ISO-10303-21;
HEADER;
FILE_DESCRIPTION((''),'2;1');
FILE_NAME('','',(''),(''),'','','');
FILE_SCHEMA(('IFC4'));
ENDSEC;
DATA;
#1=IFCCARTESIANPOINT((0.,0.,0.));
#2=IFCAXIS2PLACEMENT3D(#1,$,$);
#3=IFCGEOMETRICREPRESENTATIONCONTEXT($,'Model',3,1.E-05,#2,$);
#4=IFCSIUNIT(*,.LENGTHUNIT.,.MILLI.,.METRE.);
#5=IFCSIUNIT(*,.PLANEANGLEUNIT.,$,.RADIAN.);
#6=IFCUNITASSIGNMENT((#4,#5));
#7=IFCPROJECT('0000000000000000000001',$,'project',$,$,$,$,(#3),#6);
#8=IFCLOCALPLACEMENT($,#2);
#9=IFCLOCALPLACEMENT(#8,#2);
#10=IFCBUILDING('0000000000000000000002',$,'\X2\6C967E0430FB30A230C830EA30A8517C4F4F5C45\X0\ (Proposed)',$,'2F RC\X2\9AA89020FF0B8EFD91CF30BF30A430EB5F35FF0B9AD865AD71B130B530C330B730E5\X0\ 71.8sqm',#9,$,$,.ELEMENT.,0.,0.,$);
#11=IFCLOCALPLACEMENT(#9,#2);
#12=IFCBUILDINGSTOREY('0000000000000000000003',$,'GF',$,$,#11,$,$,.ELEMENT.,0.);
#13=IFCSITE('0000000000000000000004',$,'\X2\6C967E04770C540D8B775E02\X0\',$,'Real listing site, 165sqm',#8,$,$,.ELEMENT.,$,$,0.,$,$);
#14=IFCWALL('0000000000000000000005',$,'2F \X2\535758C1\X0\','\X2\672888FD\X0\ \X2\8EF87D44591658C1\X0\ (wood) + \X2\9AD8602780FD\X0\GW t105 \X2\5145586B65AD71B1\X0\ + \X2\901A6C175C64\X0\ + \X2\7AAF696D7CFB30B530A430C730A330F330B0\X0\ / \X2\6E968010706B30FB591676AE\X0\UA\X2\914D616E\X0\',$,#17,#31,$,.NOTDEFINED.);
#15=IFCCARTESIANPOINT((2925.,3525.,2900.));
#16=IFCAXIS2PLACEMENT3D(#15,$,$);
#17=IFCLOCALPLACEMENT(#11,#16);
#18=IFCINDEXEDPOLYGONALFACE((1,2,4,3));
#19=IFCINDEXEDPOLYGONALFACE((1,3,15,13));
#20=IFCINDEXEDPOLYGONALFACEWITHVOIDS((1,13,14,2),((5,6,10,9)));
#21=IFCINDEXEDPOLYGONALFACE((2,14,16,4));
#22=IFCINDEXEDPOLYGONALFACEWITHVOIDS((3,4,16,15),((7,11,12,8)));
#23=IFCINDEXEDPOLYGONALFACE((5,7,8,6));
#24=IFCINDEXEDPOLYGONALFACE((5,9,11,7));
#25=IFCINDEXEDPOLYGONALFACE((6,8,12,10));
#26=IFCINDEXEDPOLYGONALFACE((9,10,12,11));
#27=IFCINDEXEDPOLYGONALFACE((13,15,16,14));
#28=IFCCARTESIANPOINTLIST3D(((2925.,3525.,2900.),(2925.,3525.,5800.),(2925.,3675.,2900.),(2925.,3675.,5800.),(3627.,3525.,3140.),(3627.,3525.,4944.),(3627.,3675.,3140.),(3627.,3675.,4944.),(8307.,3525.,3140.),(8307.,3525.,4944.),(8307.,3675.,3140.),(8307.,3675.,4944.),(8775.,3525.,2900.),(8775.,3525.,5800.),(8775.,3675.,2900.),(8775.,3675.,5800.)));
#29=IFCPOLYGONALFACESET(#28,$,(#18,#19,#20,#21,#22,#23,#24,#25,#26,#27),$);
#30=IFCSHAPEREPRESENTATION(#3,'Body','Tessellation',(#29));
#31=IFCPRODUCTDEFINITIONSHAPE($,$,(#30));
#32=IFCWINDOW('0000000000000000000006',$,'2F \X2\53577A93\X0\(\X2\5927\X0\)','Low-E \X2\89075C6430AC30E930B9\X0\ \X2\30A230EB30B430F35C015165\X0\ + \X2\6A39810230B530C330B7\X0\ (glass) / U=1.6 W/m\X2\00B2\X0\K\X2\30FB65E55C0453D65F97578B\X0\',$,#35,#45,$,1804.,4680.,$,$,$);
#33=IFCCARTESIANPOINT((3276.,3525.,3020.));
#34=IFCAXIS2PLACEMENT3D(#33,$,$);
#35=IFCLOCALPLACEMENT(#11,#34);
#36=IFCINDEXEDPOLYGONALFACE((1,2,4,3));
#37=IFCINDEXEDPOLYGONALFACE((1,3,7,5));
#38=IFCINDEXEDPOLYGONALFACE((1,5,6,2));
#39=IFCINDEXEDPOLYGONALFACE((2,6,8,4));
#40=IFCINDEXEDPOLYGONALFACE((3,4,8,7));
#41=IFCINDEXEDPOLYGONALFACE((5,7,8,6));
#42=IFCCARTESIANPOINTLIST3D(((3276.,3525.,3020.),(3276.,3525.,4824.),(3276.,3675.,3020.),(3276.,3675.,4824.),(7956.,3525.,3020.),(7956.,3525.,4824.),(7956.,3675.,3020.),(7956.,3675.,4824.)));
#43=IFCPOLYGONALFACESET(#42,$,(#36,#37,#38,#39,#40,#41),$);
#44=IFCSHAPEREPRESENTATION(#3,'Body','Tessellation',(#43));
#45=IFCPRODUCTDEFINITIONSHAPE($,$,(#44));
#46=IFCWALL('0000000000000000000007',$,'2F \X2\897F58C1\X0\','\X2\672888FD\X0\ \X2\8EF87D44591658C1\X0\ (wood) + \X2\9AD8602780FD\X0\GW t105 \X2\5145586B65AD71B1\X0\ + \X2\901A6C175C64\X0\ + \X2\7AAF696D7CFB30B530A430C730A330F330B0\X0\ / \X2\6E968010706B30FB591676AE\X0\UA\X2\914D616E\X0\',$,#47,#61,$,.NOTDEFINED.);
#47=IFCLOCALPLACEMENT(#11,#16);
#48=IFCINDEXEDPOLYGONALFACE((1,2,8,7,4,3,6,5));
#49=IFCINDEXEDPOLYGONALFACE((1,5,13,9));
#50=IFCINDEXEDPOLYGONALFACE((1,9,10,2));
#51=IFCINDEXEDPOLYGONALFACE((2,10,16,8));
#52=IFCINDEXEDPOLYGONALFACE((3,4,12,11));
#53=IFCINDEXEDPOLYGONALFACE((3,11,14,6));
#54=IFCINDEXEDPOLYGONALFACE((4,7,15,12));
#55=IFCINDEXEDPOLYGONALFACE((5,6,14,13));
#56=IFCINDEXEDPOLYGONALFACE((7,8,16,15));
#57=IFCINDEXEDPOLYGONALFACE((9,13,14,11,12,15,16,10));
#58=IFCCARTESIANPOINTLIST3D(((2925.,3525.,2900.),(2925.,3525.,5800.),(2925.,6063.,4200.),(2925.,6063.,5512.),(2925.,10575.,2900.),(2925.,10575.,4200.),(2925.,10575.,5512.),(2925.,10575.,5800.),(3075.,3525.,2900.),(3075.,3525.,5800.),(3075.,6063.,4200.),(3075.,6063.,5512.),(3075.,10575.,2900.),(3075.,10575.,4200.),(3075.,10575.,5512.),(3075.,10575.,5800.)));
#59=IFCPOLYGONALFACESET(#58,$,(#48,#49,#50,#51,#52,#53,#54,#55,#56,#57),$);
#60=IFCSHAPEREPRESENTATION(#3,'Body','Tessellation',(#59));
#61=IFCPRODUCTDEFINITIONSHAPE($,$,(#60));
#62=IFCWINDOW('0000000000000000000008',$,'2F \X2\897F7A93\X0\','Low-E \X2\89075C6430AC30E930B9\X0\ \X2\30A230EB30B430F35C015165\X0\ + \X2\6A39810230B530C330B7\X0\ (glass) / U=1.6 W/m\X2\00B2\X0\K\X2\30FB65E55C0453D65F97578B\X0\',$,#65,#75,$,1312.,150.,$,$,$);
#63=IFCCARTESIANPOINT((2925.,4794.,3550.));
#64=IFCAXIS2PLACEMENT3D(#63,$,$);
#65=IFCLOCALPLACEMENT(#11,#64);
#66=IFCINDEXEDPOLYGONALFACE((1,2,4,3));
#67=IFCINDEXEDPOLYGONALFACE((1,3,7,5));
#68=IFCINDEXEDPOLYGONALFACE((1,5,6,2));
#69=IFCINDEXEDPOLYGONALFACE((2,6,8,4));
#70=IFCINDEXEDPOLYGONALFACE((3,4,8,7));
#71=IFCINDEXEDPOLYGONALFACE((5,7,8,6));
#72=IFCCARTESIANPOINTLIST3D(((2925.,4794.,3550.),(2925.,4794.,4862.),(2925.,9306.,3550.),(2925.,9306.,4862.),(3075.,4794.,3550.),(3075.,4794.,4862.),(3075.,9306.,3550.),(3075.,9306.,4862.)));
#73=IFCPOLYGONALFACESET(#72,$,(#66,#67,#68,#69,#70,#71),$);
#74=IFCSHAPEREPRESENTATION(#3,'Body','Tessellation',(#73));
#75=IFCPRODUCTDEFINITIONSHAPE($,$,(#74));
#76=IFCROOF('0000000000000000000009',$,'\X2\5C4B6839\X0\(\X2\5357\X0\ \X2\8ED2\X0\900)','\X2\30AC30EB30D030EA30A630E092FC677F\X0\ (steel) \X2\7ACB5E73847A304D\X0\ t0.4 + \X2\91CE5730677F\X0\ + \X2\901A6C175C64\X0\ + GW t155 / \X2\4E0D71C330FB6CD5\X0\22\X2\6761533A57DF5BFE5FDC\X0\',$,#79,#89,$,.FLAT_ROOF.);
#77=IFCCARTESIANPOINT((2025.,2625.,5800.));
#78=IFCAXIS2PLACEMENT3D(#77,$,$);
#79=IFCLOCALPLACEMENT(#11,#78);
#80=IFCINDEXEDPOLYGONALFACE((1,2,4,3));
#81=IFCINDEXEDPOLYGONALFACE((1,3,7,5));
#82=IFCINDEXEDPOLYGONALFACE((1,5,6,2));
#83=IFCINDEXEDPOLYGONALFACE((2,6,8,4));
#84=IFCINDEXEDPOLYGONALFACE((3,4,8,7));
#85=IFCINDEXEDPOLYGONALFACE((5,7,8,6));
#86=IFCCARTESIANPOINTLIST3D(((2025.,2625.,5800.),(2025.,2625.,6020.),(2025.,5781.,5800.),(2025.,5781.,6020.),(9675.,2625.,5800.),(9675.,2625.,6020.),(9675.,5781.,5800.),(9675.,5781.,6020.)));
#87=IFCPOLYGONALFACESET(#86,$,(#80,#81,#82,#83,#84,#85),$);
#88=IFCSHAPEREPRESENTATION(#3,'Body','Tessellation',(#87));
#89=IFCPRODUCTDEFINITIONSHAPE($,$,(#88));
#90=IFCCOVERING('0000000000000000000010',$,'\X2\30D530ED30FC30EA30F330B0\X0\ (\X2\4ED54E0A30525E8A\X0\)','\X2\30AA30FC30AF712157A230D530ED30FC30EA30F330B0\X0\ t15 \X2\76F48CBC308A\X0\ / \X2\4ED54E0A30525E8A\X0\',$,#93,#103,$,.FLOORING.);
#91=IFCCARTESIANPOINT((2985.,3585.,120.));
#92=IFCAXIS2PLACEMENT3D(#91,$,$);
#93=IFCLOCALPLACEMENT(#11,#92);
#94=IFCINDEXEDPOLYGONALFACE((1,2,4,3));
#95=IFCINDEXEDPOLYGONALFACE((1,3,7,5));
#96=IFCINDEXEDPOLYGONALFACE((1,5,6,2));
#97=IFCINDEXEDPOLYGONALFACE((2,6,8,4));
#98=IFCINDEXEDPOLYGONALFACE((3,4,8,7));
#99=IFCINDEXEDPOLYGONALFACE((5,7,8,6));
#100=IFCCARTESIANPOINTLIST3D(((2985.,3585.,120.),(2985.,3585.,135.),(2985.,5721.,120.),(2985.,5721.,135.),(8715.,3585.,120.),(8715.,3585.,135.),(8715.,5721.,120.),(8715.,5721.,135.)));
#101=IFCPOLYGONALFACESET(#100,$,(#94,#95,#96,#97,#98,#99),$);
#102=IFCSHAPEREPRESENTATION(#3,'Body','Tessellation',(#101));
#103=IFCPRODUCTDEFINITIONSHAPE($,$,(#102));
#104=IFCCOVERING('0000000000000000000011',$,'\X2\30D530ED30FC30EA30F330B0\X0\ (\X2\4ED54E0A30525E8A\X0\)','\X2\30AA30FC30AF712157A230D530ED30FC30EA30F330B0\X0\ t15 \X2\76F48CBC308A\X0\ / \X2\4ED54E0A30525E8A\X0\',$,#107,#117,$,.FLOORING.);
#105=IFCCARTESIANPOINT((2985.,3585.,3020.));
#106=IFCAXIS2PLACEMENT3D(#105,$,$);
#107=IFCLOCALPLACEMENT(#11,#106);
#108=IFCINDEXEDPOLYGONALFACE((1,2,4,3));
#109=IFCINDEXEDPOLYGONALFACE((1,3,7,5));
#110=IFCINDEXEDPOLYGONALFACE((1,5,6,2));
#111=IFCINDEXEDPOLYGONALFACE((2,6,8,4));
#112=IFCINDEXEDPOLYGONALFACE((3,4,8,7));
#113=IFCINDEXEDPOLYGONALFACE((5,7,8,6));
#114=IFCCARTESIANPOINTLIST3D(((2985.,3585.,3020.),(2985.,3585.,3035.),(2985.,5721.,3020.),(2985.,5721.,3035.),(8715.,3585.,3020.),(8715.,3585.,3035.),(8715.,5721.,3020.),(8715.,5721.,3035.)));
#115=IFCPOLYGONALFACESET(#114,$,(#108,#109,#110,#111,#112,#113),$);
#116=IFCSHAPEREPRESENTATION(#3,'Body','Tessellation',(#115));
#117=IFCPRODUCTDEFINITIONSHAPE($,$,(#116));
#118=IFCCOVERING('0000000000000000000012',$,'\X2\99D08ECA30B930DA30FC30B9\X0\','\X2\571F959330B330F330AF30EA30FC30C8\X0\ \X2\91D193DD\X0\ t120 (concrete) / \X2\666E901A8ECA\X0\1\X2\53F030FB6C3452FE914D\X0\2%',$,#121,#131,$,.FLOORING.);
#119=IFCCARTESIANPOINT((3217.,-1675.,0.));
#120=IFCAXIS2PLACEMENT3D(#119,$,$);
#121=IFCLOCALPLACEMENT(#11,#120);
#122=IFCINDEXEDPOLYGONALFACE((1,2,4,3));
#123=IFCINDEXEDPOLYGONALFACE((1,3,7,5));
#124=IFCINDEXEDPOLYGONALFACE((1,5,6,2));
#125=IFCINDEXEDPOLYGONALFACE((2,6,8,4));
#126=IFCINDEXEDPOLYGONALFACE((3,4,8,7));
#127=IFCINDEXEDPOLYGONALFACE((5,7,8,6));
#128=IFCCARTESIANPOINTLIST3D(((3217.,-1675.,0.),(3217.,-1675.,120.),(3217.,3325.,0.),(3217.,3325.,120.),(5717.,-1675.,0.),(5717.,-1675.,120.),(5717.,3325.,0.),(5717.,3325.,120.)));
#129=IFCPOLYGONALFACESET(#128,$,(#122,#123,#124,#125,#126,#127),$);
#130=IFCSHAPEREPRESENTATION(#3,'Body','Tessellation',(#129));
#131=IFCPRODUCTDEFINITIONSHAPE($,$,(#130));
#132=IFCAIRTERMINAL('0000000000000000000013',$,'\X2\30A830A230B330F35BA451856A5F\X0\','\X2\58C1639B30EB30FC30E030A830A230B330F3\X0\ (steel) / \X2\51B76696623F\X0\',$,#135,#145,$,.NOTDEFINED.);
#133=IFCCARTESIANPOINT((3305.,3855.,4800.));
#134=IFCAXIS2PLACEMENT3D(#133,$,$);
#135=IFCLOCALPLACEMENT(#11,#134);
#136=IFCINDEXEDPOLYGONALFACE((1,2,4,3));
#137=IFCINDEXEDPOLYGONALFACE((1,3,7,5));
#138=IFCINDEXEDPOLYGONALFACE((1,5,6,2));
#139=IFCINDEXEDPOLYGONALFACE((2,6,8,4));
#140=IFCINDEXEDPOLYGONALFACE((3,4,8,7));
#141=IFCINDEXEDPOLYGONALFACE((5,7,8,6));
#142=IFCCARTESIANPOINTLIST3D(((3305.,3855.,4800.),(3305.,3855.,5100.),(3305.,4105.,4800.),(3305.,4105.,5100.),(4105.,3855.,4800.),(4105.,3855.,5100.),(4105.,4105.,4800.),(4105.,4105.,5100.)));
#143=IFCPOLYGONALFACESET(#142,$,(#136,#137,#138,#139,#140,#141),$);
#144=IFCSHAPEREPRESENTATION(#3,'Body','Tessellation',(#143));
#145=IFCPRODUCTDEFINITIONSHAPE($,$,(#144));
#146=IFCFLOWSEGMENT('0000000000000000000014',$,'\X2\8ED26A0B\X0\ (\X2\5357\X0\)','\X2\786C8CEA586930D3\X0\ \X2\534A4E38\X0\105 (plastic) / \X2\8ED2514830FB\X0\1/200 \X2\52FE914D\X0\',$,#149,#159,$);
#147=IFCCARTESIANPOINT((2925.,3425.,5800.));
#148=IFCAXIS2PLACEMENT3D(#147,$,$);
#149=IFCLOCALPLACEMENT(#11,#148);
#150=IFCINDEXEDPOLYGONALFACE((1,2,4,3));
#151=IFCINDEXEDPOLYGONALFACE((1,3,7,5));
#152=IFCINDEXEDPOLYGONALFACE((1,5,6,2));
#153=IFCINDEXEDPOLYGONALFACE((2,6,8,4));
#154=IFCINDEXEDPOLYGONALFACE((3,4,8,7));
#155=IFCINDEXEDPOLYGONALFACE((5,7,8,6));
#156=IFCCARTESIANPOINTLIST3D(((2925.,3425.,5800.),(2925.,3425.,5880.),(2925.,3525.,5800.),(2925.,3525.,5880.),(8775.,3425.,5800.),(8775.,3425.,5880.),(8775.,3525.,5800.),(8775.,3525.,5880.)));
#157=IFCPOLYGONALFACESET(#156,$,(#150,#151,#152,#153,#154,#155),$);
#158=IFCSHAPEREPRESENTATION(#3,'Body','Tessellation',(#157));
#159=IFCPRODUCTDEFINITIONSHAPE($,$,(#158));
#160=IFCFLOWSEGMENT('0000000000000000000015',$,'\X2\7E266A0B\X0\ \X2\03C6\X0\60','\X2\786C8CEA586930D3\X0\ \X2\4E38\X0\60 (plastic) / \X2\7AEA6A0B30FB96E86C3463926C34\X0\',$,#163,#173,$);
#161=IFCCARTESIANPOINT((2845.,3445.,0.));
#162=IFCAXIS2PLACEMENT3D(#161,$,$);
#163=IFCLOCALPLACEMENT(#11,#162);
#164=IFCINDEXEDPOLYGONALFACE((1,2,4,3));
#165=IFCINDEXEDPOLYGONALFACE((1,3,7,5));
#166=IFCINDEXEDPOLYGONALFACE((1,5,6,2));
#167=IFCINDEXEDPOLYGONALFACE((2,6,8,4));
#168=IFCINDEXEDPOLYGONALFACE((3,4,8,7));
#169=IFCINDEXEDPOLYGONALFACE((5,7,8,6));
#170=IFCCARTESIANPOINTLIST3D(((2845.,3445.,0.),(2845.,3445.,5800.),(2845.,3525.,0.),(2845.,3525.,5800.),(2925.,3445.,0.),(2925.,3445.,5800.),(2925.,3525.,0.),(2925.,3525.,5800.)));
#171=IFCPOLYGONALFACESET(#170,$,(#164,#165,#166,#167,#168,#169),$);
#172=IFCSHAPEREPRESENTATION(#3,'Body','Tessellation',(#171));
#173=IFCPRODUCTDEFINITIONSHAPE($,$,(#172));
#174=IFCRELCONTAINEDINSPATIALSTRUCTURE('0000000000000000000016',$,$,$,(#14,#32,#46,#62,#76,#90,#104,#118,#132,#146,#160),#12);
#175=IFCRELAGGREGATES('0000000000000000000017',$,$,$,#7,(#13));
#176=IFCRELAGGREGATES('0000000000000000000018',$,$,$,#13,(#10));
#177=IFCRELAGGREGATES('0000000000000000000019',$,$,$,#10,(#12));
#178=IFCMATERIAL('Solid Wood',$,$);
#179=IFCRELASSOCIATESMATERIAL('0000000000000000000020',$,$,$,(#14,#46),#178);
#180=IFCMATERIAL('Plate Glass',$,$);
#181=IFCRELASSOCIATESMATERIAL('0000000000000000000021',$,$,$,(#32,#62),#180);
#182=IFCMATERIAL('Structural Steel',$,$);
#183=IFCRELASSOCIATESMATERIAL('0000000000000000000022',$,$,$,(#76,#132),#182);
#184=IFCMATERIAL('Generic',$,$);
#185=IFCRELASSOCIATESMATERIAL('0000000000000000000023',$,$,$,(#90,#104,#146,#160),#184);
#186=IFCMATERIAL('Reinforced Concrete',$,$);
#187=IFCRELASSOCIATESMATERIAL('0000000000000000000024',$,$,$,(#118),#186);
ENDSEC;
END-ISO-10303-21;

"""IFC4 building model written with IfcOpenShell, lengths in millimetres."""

from ifc_helpers import new_model, si_unit, frame, frame_2d, origin, place, context, project, spatial, rectangle, extrude, material, element, fill, save


model = new_model("IFC4")

# Units and contexts
model_context = context("Model", 3, precision=1e-05, world=origin())
ifc_project = project(units=[si_unit("LENGTHUNIT", "METRE", prefix="MILLI"), si_unit("PLANEANGLEUNIT", "RADIAN")], contexts=[model_context])

# Site, building, storey
site_placement = place(None, origin())
site = spatial("IfcSite", under=ifc_project, at=site_placement, Name="沖縄県名護市", ObjectType="Real listing site, 165sqm", CompositionType="ELEMENT", RefElevation=0.0)
building_placement = place(site_placement, origin())
building = spatial("IfcBuilding", under=site, at=building_placement, Name="沖縄・アトリエ兼住居 (Proposed)", ObjectType="2F RC骨造＋軽量タイル張＋高断熱サッシュ 71.8sqm", CompositionType="ELEMENT", ElevationOfRefHeight=0.0, ElevationOfTerrain=0.0)
storey_placement = place(building_placement, origin())
storey = spatial("IfcBuildingStorey", under=building, at=storey_placement, Name="GF", CompositionType="ELEMENT", Elevation=0.0)

# Shared definitions
ifc_material_1 = material(Name="Solid Wood")

# Shared definitions
ifc_material_2 = material(Name="Reinforced Concrete")

# Shared definitions
ifc_material_3 = material(Name="Plate Glass")

# Walls, openings, windows
wall_1_placement = place(storey_placement, frame((2925.0, 3525.0, 2900.0)))
wall_1 = element("IfcWall", 1, at=wall_1_placement, inside=storey, material=ifc_material_1, Name="2F 南壁", Description="木製 軸組外壁 (wood) + 高性能GW t105 充填断熱 + 通気層 + 窯業系サイディング / 準耐火・外皮UA配慮", PredefinedType="NOTDEFINED", context=model_context, shape_type="SweptSolid", body=[
    extrude(rectangle(XDim=5850.0, YDim=150.0, at=frame_2d((2925.0, 75.0))), frame((2925.0, 3525.0, 2900.0)), (0.0, 0.0, 1.0), 2900.0),
])
opening_1_placement = place(storey_placement, frame((3276.0, 3525.0, 3020.0)))
opening_1 = element("IfcOpeningElement", 2, at=opening_1_placement, cuts=wall_1, PredefinedType="NOTDEFINED", context=model_context, shape_type="SweptSolid", body=[
    extrude(rectangle(XDim=4680.0, YDim=150.0, at=frame_2d((2340.0, 75.0))), frame((3276.0, 3525.0, 3020.0)), (0.0, 0.0, 1.0), 1804.0),
])
window_1_placement = place(storey_placement, frame((3276.0, 3525.0, 3020.0)))
window_1 = element("IfcWindow", 3, at=window_1_placement, inside=storey, material=ifc_material_3, Name="2F 南窓(大)", Description="Low-E 複層ガラス アルゴン封入 + 樹脂サッシ (glass) / U=1.6 W/m²K・日射取得型", OverallHeight=1804.0, OverallWidth=4680.0, context=model_context, shape_type="SweptSolid", body=[
    extrude(rectangle(XDim=4680.0, YDim=150.0, at=frame_2d((2340.0, 75.0))), frame((3276.0, 3525.0, 3020.0)), (0.0, 0.0, 1.0), 1804.0),
])
fill(opening_1, window_1)
wall_2_placement = place(storey_placement, frame((2925.0, 3525.0, 2900.0)))
wall_2 = element("IfcWall", 4, at=wall_2_placement, inside=storey, material=ifc_material_1, Name="2F 西壁", Description="木製 軸組外壁 (wood) + 高性能GW t105 充填断熱 + 通気層 + 窯業系サイディング / 準耐火・外皮UA配慮", PredefinedType="NOTDEFINED", context=model_context, shape_type="SweptSolid", body=[
    extrude(rectangle(XDim=150.0, YDim=7050.0, at=frame_2d((75.0, 3525.0))), frame((2925.0, 3525.0, 2900.0)), (0.0, 0.0, 1.0), 2900.0),
])
opening_2_placement = place(storey_placement, frame((2925.0, 4794.0, 3550.0)))
opening_2 = element("IfcOpeningElement", 5, at=opening_2_placement, cuts=wall_2, PredefinedType="NOTDEFINED", context=model_context, shape_type="SweptSolid", body=[
    extrude(rectangle(XDim=150.0, YDim=4512.0, at=frame_2d((75.0, 2256.0))), frame((2925.0, 4794.0, 3550.0)), (0.0, 0.0, 1.0), 1312.0),
])
window_2_placement = place(storey_placement, frame((2925.0, 4794.0, 3550.0)))
window_2 = element("IfcWindow", 6, at=window_2_placement, inside=storey, material=ifc_material_3, Name="2F 西窓", Description="Low-E 複層ガラス アルゴン封入 + 樹脂サッシ (glass) / U=1.6 W/m²K・日射取得型", OverallHeight=1312.0, OverallWidth=150.0, context=model_context, shape_type="SweptSolid", body=[
    extrude(rectangle(XDim=150.0, YDim=4512.0, at=frame_2d((75.0, 2256.0))), frame((2925.0, 4794.0, 3550.0)), (0.0, 0.0, 1.0), 1312.0),
])
fill(opening_2, window_2)

# Roof
ifc_material_4 = material(Name="Structural Steel")
for number, where, name in (
    (7, (2025.0, 2625.0, 5800.0), "屋根(南 軒900)"),
):
    element("IfcRoof", number, at=place(storey_placement, frame(where)), inside=storey, material=ifc_material_4, Name=name, Description="ガルバリウム鋼板 (steel) 立平葺き t0.4 + 野地板 + 通気層 + GW t155 / 不燃・法22条区域対応", PredefinedType="FLAT_ROOF", context=model_context, shape_type="SweptSolid", body=[
        extrude(rectangle(XDim=7650.0, YDim=3156.0, at=frame_2d((3825.0, 1578.0))), frame((2025.0, 2625.0, 5800.0)), (0.0, 0.0, 1.0), 220.0),
    ])

# Coverings
ifc_material_5 = material(Name="Generic")
covering_1_placement = place(storey_placement, frame((2985.0, 3585.0, 120.0)))
element("IfcCovering", 8, at=covering_1_placement, inside=storey, material=ifc_material_5, Name="フローリング (仕上げ床)", Description="オーク無垢フローリング t15 直貼り / 仕上げ床", PredefinedType="FLOORING", context=model_context, shape_type="SweptSolid", body=[
    extrude(rectangle(XDim=5730.0, YDim=2136.0, at=frame_2d((2865.0, 1068.0))), frame((2985.0, 3585.0, 120.0)), (0.0, 0.0, 1.0), 15.0),
])
covering_2_placement = place(storey_placement, frame((2985.0, 3585.0, 3020.0)))
element("IfcCovering", 9, at=covering_2_placement, inside=storey, material=ifc_material_5, Name="フローリング (仕上げ床)", Description="オーク無垢フローリング t15 直貼り / 仕上げ床", PredefinedType="FLOORING", context=model_context, shape_type="SweptSolid", body=[
    extrude(rectangle(XDim=5730.0, YDim=2136.0, at=frame_2d((2865.0, 1068.0))), frame((2985.0, 3585.0, 3020.0)), (0.0, 0.0, 1.0), 15.0),
])
covering_3_placement = place(storey_placement, frame((3217.0, -1675.0, 0.0)))
element("IfcCovering", 10, at=covering_3_placement, inside=storey, material=ifc_material_2, Name="駐車スペース", Description="土間コンクリート 金鏝 t120 (concrete) / 普通車1台・水勾配2%", PredefinedType="FLOORING", context=model_context, shape_type="SweptSolid", body=[
    extrude(rectangle(XDim=2500.0, YDim=5000.0, at=frame_2d((1250.0, 2500.0))), frame((3217.0, -1675.0, 0.0)), (0.0, 0.0, 1.0), 120.0),
])

# Air terminal
air_terminal_placement = place(storey_placement, frame((3305.0, 3855.0, 4800.0)))
element("IfcAirTerminal", 11, at=air_terminal_placement, inside=storey, material=ifc_material_4, Name="エアコン室内機", Description="壁掛ルームエアコン (steel) / 冷暖房", PredefinedType="NOTDEFINED", context=model_context, shape_type="SweptSolid", body=[
    extrude(rectangle(XDim=800.0, YDim=250.0, at=frame_2d((400.0, 125.0))), frame((3305.0, 3855.0, 4800.0)), (0.0, 0.0, 1.0), 300.0),
])

# Flow segments
flow_segment_1_placement = place(storey_placement, frame((2925.0, 3425.0, 5800.0)))
element("IfcFlowSegment", 12, at=flow_segment_1_placement, inside=storey, material=ifc_material_5, Name="軒樋 (南)", Description="硬質塩ビ 半丸105 (plastic) / 軒先・1/200 勾配", context=model_context, shape_type="SweptSolid", body=[
    extrude(rectangle(XDim=5850.0, YDim=100.0, at=frame_2d((2925.0, 50.0))), frame((2925.0, 3425.0, 5800.0)), (0.0, 0.0, 1.0), 80.0),
])
flow_segment_2_placement = place(storey_placement, frame((2845.0, 3445.0, 0.0)))
element("IfcFlowSegment", 13, at=flow_segment_2_placement, inside=storey, material=ifc_material_5, Name="縦樋 φ60", Description="硬質塩ビ 丸60 (plastic) / 竪樋・雨水排水", context=model_context, shape_type="SweptSolid", body=[
    extrude(rectangle(XDim=80.0, YDim=80.0, at=frame_2d((40.0, 40.0))), frame((2845.0, 3445.0, 0.0)), (0.0, 0.0, 1.0), 5800.0),
])

save(model, "model.ifc")
